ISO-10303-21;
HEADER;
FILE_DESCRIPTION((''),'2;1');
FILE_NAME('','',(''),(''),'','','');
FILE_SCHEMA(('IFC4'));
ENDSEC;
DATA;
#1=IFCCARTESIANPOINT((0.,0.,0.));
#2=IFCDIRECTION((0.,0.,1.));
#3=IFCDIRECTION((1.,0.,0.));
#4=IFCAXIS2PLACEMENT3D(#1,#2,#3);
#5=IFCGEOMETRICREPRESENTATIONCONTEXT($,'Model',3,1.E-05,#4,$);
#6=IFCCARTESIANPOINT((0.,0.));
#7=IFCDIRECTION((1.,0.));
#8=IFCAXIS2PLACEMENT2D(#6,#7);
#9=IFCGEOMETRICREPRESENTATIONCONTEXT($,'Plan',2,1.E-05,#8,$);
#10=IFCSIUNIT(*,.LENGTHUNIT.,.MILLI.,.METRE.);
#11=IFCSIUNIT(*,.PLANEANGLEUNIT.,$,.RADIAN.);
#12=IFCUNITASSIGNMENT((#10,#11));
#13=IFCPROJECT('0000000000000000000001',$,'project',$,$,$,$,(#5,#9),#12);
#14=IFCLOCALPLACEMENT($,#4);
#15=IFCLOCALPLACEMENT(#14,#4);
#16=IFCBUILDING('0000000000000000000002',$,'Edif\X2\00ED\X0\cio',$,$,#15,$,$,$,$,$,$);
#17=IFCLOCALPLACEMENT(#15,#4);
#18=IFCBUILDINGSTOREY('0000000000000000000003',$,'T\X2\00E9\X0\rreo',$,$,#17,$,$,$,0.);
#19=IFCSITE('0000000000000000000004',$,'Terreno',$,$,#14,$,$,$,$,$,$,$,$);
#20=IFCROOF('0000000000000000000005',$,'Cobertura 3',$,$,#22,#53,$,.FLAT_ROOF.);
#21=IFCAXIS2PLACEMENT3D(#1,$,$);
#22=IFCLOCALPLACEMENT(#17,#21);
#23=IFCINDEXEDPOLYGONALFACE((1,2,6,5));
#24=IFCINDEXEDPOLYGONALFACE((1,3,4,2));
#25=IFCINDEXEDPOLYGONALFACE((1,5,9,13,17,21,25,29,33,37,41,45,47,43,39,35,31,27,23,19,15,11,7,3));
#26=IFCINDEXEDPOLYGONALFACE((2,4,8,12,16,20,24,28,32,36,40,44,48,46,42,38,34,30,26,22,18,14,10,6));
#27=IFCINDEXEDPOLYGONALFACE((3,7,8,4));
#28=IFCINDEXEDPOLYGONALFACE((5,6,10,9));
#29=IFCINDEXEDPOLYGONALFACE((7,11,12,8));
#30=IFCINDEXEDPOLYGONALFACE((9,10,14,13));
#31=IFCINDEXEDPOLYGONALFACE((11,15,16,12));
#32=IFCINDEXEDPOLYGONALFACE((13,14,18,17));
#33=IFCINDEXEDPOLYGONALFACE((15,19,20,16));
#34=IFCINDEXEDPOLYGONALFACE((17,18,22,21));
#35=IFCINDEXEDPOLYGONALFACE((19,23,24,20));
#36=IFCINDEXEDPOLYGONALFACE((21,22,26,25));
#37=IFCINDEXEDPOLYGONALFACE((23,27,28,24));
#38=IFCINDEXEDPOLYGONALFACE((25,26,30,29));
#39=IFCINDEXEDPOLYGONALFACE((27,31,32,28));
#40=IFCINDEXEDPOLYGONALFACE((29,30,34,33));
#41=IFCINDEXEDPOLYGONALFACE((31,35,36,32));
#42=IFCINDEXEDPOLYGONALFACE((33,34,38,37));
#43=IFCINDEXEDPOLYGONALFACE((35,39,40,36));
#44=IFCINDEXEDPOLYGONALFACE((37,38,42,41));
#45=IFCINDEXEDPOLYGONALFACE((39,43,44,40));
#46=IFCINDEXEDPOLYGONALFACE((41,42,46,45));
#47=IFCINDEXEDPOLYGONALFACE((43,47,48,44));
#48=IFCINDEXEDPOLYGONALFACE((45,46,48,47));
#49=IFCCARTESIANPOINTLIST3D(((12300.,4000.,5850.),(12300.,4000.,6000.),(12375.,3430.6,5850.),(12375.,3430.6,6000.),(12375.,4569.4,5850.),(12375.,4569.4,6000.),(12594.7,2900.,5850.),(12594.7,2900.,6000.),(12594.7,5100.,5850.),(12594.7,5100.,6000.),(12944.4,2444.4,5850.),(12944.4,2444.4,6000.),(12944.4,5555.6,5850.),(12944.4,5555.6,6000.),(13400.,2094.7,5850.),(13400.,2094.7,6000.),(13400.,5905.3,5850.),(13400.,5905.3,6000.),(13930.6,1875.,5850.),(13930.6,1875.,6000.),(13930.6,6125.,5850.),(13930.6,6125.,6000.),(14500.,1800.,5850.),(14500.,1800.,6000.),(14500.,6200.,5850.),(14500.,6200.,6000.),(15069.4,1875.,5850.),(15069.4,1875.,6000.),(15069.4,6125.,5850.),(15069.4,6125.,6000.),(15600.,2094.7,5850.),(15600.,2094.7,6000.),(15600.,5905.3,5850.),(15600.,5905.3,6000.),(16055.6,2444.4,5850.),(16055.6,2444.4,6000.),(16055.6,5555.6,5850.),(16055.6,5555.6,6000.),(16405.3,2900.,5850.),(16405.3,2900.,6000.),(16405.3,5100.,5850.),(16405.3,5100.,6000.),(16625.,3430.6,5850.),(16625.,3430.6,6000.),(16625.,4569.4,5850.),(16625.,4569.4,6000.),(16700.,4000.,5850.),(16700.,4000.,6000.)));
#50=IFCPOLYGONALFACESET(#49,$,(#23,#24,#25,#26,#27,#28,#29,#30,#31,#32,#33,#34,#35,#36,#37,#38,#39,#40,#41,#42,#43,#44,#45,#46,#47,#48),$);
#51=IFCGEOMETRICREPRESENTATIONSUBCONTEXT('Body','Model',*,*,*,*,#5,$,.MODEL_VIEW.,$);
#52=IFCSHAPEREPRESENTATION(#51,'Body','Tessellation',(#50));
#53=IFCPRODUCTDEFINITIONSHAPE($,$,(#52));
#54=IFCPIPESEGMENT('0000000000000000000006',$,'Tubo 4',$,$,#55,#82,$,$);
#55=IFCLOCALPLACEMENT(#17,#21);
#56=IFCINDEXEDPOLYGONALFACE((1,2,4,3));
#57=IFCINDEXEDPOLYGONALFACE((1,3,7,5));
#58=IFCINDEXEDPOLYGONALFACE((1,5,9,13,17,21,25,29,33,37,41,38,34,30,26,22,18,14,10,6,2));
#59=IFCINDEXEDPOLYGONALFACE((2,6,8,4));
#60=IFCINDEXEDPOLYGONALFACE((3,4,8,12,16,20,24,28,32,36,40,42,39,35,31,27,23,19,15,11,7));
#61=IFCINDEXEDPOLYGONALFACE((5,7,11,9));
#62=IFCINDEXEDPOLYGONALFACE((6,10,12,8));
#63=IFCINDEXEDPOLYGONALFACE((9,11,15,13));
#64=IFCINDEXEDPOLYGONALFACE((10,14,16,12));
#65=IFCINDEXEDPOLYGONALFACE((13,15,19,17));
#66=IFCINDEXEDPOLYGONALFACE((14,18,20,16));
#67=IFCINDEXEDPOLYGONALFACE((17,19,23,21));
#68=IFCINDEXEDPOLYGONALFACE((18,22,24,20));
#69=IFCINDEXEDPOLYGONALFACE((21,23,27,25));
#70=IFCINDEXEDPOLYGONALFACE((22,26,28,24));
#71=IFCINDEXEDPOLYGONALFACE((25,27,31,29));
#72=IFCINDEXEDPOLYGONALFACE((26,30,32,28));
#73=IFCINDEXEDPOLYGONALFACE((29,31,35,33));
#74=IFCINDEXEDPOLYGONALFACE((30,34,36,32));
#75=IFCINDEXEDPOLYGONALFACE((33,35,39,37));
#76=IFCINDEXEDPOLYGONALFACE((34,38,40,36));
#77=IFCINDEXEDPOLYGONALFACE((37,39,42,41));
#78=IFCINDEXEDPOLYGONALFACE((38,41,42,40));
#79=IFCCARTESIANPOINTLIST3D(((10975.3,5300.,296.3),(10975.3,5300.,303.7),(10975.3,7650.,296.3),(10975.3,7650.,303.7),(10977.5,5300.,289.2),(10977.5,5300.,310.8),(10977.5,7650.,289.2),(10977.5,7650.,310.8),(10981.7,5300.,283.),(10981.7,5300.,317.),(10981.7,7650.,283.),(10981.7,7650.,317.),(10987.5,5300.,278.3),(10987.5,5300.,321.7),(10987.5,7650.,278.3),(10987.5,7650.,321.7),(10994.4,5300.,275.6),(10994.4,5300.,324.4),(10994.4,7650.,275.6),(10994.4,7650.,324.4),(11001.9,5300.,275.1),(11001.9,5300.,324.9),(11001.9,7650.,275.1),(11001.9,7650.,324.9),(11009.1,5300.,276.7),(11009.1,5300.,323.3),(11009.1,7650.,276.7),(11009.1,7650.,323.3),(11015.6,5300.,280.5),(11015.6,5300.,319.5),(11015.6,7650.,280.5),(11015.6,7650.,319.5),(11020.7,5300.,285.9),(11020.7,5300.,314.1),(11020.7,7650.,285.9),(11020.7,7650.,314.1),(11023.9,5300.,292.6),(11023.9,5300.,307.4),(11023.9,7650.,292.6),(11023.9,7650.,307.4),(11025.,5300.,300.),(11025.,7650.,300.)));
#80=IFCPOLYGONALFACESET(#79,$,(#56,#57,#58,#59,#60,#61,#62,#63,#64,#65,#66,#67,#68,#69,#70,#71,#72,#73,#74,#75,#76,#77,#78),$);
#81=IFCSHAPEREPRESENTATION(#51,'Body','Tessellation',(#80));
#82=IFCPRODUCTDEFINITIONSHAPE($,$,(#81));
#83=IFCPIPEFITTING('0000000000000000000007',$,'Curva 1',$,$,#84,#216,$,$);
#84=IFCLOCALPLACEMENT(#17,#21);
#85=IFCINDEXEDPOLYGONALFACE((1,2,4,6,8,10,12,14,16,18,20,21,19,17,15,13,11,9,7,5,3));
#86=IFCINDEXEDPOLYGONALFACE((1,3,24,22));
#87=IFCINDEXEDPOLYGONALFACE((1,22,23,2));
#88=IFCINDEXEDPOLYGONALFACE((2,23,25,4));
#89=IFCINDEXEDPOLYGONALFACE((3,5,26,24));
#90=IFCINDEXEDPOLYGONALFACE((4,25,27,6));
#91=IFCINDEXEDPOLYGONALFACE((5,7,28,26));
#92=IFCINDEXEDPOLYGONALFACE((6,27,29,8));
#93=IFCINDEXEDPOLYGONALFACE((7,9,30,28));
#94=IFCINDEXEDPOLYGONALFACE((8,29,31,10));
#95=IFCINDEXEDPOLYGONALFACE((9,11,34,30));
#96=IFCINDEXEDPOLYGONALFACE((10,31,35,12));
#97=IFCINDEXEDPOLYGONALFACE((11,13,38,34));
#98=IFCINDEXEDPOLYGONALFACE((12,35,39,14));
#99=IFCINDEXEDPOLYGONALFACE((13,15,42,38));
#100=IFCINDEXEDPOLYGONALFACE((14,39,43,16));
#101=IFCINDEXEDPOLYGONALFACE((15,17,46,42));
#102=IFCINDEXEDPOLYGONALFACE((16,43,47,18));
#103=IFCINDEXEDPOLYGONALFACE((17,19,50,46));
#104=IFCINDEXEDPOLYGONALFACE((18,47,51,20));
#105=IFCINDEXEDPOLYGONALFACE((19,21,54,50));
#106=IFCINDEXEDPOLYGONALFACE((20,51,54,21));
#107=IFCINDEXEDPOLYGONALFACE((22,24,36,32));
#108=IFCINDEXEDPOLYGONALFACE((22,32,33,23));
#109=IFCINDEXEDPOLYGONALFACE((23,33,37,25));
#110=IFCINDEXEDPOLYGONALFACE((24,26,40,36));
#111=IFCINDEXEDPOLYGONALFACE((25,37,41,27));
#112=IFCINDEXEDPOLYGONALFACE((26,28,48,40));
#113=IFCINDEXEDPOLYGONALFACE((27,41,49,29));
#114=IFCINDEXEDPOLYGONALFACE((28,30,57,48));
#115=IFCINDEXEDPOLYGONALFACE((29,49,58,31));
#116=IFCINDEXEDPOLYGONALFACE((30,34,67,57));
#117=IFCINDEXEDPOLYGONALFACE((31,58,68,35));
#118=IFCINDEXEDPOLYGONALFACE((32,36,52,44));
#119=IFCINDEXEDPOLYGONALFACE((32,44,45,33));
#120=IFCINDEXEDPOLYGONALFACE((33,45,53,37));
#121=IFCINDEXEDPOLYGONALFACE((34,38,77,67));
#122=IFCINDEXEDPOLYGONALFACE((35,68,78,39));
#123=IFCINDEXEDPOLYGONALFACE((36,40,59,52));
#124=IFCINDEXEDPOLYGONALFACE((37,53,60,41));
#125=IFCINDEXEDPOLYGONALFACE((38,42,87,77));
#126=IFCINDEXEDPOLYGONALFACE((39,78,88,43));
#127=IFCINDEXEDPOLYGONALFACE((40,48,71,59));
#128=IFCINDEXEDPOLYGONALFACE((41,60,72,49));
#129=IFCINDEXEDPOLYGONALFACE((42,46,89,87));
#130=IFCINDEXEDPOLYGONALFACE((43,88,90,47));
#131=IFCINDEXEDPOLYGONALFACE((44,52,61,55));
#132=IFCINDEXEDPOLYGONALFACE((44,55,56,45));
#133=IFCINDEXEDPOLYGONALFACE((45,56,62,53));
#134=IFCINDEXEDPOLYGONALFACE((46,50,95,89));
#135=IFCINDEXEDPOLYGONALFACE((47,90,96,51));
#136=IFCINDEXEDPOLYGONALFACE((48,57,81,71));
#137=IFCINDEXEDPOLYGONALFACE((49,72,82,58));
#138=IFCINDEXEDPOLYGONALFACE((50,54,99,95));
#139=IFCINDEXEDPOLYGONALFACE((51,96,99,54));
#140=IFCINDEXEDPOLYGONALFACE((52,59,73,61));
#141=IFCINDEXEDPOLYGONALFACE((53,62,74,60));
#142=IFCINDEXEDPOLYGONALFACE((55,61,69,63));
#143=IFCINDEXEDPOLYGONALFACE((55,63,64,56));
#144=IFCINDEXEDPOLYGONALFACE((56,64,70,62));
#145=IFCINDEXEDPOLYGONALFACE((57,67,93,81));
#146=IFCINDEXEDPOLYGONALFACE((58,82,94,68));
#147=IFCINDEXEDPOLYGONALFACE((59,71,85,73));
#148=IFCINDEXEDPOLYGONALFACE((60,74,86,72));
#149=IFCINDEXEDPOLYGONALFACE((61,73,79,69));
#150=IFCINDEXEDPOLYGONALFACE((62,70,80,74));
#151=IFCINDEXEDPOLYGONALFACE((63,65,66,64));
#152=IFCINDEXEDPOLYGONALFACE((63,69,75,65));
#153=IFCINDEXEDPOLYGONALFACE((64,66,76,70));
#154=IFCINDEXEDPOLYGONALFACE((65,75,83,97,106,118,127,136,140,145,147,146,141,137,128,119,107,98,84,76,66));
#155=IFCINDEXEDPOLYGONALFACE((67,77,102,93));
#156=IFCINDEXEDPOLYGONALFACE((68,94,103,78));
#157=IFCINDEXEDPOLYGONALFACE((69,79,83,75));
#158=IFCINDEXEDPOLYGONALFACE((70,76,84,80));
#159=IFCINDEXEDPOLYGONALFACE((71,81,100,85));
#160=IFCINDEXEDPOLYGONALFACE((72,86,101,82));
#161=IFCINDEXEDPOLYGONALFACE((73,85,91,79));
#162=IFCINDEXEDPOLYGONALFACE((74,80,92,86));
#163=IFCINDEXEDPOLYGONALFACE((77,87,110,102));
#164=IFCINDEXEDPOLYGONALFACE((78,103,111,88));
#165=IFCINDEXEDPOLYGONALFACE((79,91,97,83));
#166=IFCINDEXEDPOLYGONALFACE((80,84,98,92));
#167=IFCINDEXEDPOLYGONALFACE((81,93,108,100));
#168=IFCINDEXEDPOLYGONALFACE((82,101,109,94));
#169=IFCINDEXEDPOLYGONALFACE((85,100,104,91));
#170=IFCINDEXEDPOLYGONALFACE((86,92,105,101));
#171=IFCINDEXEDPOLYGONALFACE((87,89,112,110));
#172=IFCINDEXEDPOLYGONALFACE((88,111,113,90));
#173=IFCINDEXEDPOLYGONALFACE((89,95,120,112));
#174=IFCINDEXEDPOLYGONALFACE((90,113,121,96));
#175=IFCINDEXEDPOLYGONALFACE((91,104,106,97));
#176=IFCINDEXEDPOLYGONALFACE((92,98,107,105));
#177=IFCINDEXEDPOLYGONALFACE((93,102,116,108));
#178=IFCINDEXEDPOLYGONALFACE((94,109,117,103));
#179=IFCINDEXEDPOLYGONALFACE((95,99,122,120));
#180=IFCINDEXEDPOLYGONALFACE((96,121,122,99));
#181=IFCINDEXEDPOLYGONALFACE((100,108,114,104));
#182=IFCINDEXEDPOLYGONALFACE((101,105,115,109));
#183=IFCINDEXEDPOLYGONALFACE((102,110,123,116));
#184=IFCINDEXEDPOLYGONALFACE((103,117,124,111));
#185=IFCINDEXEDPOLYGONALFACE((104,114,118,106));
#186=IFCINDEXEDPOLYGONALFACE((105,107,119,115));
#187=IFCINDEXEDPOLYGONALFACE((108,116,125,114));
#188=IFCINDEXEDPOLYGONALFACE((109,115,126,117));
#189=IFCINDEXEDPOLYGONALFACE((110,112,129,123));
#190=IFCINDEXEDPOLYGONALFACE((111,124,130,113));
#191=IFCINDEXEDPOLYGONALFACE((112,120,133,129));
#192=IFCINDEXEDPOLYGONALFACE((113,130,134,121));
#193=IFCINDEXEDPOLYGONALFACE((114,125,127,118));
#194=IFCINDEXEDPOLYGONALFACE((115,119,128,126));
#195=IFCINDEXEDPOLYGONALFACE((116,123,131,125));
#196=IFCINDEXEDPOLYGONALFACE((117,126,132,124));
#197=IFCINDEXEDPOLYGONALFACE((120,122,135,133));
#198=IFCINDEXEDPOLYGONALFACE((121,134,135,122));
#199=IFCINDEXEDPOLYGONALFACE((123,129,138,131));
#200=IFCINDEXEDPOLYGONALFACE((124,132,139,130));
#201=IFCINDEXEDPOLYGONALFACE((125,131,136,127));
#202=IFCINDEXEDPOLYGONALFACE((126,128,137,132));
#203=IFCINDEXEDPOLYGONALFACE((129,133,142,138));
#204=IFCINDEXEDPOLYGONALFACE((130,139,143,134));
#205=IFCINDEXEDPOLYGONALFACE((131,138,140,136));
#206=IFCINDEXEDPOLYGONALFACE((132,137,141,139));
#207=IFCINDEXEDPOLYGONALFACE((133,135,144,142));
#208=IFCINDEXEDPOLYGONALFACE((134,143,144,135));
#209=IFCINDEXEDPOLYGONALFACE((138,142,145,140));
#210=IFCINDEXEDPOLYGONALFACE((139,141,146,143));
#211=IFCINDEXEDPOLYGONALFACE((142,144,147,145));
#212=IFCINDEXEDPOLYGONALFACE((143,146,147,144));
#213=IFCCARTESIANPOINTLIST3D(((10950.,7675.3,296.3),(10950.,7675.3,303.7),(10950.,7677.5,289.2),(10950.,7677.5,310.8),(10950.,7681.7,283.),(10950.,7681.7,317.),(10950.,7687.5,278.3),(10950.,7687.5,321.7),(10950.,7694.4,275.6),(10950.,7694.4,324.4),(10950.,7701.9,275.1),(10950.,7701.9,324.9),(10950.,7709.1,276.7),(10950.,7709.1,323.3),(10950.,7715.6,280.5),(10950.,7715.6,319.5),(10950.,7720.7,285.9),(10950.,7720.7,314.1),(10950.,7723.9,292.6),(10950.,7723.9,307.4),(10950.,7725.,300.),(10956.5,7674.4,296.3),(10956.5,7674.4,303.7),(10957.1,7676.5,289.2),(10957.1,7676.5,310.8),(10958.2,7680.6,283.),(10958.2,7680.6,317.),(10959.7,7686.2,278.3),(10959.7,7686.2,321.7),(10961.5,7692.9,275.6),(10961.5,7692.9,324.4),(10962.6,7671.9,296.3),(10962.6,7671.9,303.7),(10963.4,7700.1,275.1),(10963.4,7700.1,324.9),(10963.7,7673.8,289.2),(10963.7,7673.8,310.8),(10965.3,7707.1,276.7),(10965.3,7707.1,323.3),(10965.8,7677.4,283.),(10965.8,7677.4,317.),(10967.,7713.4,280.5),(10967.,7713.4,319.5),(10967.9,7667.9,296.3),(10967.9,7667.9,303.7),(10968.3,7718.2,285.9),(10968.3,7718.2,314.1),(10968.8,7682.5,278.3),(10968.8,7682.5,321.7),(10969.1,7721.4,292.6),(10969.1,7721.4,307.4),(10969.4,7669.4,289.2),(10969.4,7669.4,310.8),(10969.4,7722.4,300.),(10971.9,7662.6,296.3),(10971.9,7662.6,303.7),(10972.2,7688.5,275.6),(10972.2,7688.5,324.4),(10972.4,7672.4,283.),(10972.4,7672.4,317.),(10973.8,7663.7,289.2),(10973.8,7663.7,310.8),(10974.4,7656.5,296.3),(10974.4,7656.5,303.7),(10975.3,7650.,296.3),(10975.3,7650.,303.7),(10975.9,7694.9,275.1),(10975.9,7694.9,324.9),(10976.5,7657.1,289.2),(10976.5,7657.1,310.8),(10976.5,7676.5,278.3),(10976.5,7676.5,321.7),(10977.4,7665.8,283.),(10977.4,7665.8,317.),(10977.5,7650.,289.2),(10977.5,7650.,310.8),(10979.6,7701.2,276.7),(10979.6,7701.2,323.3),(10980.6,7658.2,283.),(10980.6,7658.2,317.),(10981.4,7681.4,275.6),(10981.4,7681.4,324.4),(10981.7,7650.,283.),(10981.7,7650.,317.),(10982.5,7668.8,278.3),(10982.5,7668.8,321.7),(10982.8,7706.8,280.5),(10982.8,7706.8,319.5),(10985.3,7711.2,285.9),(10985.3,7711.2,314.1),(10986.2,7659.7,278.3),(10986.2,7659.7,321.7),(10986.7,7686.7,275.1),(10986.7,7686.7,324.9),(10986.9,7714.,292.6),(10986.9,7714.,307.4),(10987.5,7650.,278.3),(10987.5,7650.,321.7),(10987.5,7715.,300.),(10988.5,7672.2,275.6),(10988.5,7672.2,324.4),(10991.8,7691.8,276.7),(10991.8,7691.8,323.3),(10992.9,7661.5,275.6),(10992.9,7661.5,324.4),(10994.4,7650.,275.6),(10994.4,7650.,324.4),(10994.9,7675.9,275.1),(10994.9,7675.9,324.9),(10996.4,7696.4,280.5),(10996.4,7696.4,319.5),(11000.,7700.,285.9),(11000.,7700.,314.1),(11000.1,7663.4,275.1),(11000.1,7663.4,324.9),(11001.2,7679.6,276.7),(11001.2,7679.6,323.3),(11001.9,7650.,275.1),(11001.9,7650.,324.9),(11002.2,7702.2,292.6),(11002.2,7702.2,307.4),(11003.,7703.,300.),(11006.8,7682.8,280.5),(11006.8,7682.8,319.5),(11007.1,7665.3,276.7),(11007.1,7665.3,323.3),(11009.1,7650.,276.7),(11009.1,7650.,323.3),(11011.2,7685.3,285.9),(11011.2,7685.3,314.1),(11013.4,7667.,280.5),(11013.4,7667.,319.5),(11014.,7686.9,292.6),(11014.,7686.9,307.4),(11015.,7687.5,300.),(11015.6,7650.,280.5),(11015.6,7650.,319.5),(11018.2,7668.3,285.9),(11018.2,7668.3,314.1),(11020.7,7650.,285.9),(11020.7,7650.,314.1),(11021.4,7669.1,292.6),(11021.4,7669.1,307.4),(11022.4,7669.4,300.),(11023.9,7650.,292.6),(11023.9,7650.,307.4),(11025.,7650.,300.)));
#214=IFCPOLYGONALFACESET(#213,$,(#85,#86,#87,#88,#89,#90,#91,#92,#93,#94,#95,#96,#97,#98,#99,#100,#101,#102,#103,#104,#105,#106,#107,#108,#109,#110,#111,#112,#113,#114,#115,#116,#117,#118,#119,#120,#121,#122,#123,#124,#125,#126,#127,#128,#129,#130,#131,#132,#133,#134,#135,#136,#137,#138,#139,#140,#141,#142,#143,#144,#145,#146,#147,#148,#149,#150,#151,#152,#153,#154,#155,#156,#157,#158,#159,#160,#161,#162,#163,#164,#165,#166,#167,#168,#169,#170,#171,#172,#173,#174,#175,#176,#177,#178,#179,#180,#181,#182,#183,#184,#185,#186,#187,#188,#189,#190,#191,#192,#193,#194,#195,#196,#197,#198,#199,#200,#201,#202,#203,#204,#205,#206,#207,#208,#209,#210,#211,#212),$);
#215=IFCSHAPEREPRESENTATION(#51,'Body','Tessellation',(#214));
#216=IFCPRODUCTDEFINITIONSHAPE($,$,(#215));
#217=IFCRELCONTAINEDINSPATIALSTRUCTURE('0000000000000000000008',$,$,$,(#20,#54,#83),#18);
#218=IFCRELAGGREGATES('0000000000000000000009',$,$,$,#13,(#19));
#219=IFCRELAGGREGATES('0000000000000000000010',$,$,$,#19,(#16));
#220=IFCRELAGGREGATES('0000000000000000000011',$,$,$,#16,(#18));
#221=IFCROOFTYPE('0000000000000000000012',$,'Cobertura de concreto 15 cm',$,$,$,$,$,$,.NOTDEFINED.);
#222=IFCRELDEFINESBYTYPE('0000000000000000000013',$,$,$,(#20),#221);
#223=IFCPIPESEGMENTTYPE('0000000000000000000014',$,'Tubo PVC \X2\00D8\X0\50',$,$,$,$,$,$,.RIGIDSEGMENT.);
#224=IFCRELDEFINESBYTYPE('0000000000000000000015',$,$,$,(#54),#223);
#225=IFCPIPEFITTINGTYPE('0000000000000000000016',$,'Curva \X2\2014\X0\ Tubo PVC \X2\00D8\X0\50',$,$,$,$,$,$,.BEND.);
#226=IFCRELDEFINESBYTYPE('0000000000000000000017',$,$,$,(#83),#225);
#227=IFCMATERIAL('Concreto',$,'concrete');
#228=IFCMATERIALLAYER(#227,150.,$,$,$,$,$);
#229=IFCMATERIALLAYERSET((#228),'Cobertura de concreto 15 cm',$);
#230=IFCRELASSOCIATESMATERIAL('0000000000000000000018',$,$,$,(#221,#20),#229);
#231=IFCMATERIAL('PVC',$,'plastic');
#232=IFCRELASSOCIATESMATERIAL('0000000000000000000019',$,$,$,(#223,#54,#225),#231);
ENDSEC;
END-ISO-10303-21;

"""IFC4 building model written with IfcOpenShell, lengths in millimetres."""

from ifc_helpers import new_model, entity, si_unit, frame, origin_with_axes, origin_2d_with_axis, place, context, subcontext, project, spatial, indexed_curve, circle, outline, extrude, material, layer, layer_set, material_profile, profile_set, profile_usage, type_object, element, save


model = new_model("IFC4")

# Units and contexts
model_context = context("Model", 3, precision=1e-05, world=origin_with_axes())
plan_context = context("Plan", 2, precision=1e-05, world=origin_2d_with_axis())
body_context = subcontext(model_context, "Body", "Model", "MODEL_VIEW")
ifc_project = project(units=[si_unit("LENGTHUNIT", "METRE", prefix="MILLI"), si_unit("PLANEANGLEUNIT", "RADIAN")], contexts=[model_context, plan_context])

# Site, building, storey
site_placement = place(None, origin_with_axes())
site = spatial("IfcSite", under=ifc_project, at=site_placement, Name="Terreno")
building_placement = place(site_placement, origin_with_axes())
building = spatial("IfcBuilding", under=site, at=building_placement, Name="Edifício")
storey_placement = place(building_placement, origin_with_axes())
storey = spatial("IfcBuildingStorey", under=building, at=storey_placement, Name="Térreo", Elevation=0.0)

# Shared definitions
ifc_material_1 = material(Name="Concreto", Category="concrete")

# Roof
ifc_layer_1 = layer(ifc_material_1, 150.0)
ifc_layer_set_1 = layer_set([ifc_layer_1], Name="Cobertura de concreto 15 cm")
roof_type = type_object("IfcRoofType", Name="Cobertura de concreto 15 cm", PredefinedType="NOTDEFINED", material=ifc_layer_set_1)
roof_placement = place(storey_placement, frame((16700.0, 4000.0, 6000.0), z_axis=(0.0, 0.0, 1.0), x_axis=(1.0, 0.0, 0.0)))
element("IfcRoof", 1, at=roof_placement, inside=storey, type_object=roof_type, material=ifc_layer_set_1, Name="Cobertura 3", PredefinedType="FLAT_ROOF", context=body_context, shape_type="SweptSolid", body=[
    extrude(outline(indexed_curve([(0.0, 0.0), (-75.0, 569.4), (-294.7, 1100.0), (-644.4, 1555.6), (-1100.0, 1905.3), (-1630.6, 2125.0), (-2200.0, 2200.0), (-2769.4, 2125.0), (-3300.0, 1905.3), (-3755.6, 1555.6), (-4105.3, 1100.0), (-4325.0, 569.4), (-4400.0, 0.0), (-4325.0, -569.4), (-4105.3, -1100.0), (-3755.6, -1555.6), (-3300.0, -1905.3), (-2769.4, -2125.0), (-2200.0, -2200.0), (-1630.6, -2125.0), (-1100.0, -1905.3), (-644.4, -1555.6), (-294.7, -1100.0), (-75.0, -569.4), (0.0, 0.0)], self_intersect=False)), origin_with_axes(), (0.0, 0.0, -1.0), 150.0),
])

# Pipe segment
ifc_material_2 = material(Name="PVC", Category="plastic")
ifc_material_profile_1 = material_profile(ifc_material_2, circle(Radius=25.0))
ifc_profile_set_1 = profile_set([ifc_material_profile_1], Name="Tubo PVC Ø50")
ifc_profile_usage_1 = profile_usage(ifc_profile_set_1)
pipe_segment_type = type_object("IfcPipeSegmentType", Name="Tubo PVC Ø50", PredefinedType="RIGIDSEGMENT", material=ifc_profile_set_1)
pipe_segment_placement = place(storey_placement, frame((11000.0, 7650.0, 300.0), z_axis=(0.0, -1.0, 0.0), x_axis=(1.0, 0.0, 0.0)))
element("IfcPipeSegment", 2, at=pipe_segment_placement, inside=storey, type_object=pipe_segment_type, material=ifc_profile_usage_1, Name="Tubo 4", context=body_context, shape_type="SweptSolid", body=[
    extrude(circle(Radius=25.0), origin_with_axes(), (0.0, 0.0, 1.0), 2350.0),
])

# Pipe fitting
pipe_fitting_type = type_object("IfcPipeFittingType", Name="Curva — Tubo PVC Ø50", PredefinedType="BEND", material=ifc_material_2)
pipe_fitting_placement = place(storey_placement, frame((10950.0, 7700.0, 300.0), z_axis=(1.0, 0.0, 0.0), x_axis=(0.0, 1.0, 0.0)))
element("IfcPipeFitting", 3, at=pipe_fitting_placement, inside=storey, type_object=pipe_fitting_type, Name="Curva 1", context=body_context, shape_type="SweptSolid", body=[
    entity("IfcRevolvedAreaSolid", entity("IfcCircleProfileDef", "AREA", None, None, 25.0), entity("IfcAxis2Placement3D", entity("IfcCartesianPoint", [0.0, 0.0, 0.0])), entity("IfcAxis1Placement", entity("IfcCartesianPoint", [-50.0, 0.0, 0.0]), entity("IfcDirection", [0.0, -1.0, 0.0])), 1.570796),
])

save(model, "model.ifc")
